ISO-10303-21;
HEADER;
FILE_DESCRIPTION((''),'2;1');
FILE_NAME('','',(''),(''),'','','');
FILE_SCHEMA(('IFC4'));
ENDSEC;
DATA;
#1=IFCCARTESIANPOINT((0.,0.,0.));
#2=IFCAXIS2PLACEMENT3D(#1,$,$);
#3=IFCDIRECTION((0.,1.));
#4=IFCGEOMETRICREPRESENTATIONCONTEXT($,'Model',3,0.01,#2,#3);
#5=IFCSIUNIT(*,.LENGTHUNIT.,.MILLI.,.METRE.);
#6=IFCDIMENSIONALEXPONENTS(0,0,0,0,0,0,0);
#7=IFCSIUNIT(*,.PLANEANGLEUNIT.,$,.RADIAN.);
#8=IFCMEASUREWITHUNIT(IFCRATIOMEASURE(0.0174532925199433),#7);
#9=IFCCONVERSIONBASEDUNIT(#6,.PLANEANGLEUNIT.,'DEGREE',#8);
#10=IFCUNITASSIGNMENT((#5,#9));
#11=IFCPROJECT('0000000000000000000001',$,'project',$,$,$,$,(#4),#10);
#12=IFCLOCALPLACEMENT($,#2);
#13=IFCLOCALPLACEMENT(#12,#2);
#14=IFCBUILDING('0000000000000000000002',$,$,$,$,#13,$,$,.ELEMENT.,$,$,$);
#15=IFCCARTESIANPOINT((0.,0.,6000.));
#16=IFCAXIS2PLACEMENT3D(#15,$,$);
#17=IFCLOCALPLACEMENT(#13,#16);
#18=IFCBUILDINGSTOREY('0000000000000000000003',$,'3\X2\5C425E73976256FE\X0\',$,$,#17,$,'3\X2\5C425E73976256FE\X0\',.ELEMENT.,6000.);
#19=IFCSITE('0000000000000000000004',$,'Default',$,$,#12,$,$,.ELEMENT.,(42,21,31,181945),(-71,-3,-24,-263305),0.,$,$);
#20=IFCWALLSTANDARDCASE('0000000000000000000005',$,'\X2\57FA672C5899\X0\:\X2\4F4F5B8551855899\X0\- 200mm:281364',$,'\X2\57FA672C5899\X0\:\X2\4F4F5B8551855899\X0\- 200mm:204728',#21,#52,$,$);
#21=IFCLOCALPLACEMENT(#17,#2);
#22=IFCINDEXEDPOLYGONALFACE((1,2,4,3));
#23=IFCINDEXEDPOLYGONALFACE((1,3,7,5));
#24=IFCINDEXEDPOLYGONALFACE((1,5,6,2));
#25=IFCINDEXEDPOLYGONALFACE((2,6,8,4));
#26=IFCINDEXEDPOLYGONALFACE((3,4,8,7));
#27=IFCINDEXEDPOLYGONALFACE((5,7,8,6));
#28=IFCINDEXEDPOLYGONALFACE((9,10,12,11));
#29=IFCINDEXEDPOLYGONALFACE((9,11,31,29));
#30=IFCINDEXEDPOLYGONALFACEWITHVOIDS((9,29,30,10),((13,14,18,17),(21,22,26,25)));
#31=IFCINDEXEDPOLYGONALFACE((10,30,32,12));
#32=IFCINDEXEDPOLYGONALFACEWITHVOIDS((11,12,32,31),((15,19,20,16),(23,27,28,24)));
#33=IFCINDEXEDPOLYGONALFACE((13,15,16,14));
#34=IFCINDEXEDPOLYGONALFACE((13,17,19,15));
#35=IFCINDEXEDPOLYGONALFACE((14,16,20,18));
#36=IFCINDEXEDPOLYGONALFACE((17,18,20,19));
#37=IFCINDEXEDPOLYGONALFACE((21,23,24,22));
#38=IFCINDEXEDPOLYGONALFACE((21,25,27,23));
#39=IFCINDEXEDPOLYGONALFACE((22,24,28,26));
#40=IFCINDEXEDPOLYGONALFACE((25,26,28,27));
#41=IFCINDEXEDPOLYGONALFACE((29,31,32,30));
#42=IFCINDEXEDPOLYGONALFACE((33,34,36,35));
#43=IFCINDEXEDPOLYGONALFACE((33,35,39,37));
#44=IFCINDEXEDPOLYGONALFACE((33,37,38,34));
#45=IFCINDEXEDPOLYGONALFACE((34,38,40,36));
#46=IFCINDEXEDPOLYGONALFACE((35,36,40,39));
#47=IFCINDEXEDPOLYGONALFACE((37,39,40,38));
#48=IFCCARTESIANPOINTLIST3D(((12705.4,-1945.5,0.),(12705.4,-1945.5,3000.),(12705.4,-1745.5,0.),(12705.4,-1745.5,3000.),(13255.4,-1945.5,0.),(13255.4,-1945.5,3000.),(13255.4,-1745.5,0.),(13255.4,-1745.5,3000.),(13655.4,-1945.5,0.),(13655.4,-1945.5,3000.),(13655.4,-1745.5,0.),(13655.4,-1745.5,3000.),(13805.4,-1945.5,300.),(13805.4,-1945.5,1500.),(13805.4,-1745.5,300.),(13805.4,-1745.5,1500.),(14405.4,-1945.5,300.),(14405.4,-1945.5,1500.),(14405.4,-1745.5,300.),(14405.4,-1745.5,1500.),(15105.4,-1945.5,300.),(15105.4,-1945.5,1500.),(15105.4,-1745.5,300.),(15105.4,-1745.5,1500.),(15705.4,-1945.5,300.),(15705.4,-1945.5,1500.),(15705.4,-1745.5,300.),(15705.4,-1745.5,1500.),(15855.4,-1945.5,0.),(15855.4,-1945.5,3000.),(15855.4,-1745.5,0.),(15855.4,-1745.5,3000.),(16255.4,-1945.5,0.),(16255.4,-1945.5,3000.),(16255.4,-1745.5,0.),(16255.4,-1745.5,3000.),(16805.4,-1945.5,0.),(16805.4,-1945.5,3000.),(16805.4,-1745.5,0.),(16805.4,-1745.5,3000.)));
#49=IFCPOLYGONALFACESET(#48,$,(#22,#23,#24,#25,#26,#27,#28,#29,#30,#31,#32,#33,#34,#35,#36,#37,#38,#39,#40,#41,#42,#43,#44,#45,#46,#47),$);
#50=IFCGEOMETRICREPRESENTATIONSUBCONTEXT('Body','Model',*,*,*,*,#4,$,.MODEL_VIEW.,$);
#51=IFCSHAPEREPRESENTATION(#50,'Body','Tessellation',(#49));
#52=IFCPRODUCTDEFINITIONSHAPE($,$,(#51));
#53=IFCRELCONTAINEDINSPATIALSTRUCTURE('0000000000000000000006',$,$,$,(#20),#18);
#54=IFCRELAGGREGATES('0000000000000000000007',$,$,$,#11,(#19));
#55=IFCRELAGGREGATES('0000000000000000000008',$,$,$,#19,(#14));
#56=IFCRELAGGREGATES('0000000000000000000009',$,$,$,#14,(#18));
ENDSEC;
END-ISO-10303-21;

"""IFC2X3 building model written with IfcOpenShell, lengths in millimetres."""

from ifc_helpers import new_model, entity, si_unit, converted_unit, direction, frame, frame_2d, origin, origin_2d_with_axis, place, context, subcontext, project, spatial, rectangle, extrude, element, save


model = new_model("IFC2X3")

# Units and contexts
model_context = context("Model", 3, precision=0.01, world=origin(), true_north=direction((0.0, 1.0)))
body_context = subcontext(model_context, "Body", "Model", "MODEL_VIEW")
ifc_project = project(units=[si_unit("LENGTHUNIT", "METRE", prefix="MILLI"), converted_unit("PLANEANGLEUNIT", "DEGREE", entity("IfcRatioMeasure", 0.0174532925199433), si_unit("PLANEANGLEUNIT", "RADIAN"), dimensions=[0, 0, 0, 0, 0, 0, 0])], contexts=[model_context])

# Site, building, storey
site_placement = place(None, origin())
site = spatial("IfcSite", under=ifc_project, at=site_placement, Name="Default", CompositionType="ELEMENT", RefLatitude=(42, 21, 31, 181945), RefLongitude=(-71, -3, -24, -263305), RefElevation=0.0)
building_placement = place(site_placement, origin())
building = spatial("IfcBuilding", under=site, at=building_placement, CompositionType="ELEMENT")
storey_placement = place(building_placement, frame((0.0, 0.0, 6000.0)))
storey = spatial("IfcBuildingStorey", under=building, at=storey_placement, Name="3层平面图", LongName="3层平面图", CompositionType="ELEMENT", Elevation=6000.0)

# Wall, openings
wall_1_placement = place(storey_placement, frame((16805.4, -1845.5, 0.0), z_axis=(0.0, 0.0, 1.0), x_axis=(-1.0, 0.0, 0.0)))
wall_1 = element("IfcWallStandardCase", 1, at=wall_1_placement, inside=storey, Name="基本墙:住宅内墙- 200mm:281364", ObjectType="基本墙:住宅内墙- 200mm:204728", context=body_context, shape_type="SweptSolid", body=[
    extrude(rectangle(XDim=4100.0, YDim=200.0, at=frame_2d((2050.0, 0.0), x_axis=(-1.0, 0.0))), origin(), (0.0, 0.0, 1.0), 3000.0),
])
opening_1_placement = place(wall_1_placement, frame((1100.0, -100.0, 300.0)))
element("IfcOpeningElement", 2, at=opening_1_placement, cuts=wall_1, ObjectType="Opening", context=body_context, shape_type="SweptSolid", body=[
    extrude(rectangle(XDim=1200.0, YDim=600.0, at=frame_2d((600.0, 300.0), x_axis=(-1.0, 0.0))), frame((0.0, 0.0, 0.0), z_axis=(0.0, 1.0, 0.0), x_axis=(0.0, 0.0, 1.0)), (0.0, 0.0, 1.0), 200.0),
])
opening_2_placement = place(wall_1_placement, frame((2400.0, -100.0, 300.0)))
element("IfcOpeningElement", 3, at=opening_2_placement, cuts=wall_1, ObjectType="Opening", context=body_context, shape_type="SweptSolid", body=[
    extrude(rectangle(XDim=1200.0, YDim=600.0, at=frame_2d((600.0, 300.0), x_axis=(-1.0, 0.0))), frame((0.0, 0.0, 0.0), z_axis=(0.0, 1.0, 0.0), x_axis=(0.0, 0.0, 1.0)), (0.0, 0.0, 1.0), 200.0),
])
opening_3_placement = place(storey_placement, frame((16805.4, -1845.5, 0.0), z_axis=(0.0, 0.0, 1.0), x_axis=(-1.0, 0.0, 0.0)))
element("IfcOpeningElement", 4, at=opening_3_placement, cuts=wall_1, ObjectType="Opening", context=body_context, shape_type="SweptSolid", body=[
    extrude(rectangle(XDim=3000.0, YDim=200.0, at=origin_2d_with_axis()), frame((3550.0, 0.0, 1500.0), z_axis=(-1.0, 0.0, 0.0), x_axis=(0.0, 0.0, 1.0)), (0.0, 0.0, 1.0), 400.0),
])
opening_4_placement = place(storey_placement, frame((16805.4, -1845.5, 0.0), z_axis=(0.0, 0.0, 1.0), x_axis=(-1.0, 0.0, 0.0)))
element("IfcOpeningElement", 5, at=opening_4_placement, cuts=wall_1, ObjectType="Opening", context=body_context, shape_type="SweptSolid", body=[
    extrude(rectangle(XDim=3000.0, YDim=200.0, at=frame_2d((0.0, 0.0), x_axis=(1.0, 0.0))), frame((950.0, 0.0, 1500.0), z_axis=(-1.0, 0.0, 0.0), x_axis=(0.0, 0.0, 1.0)), (0.0, 0.0, 1.0), 400.0),
])

save(model, "model.ifc")
